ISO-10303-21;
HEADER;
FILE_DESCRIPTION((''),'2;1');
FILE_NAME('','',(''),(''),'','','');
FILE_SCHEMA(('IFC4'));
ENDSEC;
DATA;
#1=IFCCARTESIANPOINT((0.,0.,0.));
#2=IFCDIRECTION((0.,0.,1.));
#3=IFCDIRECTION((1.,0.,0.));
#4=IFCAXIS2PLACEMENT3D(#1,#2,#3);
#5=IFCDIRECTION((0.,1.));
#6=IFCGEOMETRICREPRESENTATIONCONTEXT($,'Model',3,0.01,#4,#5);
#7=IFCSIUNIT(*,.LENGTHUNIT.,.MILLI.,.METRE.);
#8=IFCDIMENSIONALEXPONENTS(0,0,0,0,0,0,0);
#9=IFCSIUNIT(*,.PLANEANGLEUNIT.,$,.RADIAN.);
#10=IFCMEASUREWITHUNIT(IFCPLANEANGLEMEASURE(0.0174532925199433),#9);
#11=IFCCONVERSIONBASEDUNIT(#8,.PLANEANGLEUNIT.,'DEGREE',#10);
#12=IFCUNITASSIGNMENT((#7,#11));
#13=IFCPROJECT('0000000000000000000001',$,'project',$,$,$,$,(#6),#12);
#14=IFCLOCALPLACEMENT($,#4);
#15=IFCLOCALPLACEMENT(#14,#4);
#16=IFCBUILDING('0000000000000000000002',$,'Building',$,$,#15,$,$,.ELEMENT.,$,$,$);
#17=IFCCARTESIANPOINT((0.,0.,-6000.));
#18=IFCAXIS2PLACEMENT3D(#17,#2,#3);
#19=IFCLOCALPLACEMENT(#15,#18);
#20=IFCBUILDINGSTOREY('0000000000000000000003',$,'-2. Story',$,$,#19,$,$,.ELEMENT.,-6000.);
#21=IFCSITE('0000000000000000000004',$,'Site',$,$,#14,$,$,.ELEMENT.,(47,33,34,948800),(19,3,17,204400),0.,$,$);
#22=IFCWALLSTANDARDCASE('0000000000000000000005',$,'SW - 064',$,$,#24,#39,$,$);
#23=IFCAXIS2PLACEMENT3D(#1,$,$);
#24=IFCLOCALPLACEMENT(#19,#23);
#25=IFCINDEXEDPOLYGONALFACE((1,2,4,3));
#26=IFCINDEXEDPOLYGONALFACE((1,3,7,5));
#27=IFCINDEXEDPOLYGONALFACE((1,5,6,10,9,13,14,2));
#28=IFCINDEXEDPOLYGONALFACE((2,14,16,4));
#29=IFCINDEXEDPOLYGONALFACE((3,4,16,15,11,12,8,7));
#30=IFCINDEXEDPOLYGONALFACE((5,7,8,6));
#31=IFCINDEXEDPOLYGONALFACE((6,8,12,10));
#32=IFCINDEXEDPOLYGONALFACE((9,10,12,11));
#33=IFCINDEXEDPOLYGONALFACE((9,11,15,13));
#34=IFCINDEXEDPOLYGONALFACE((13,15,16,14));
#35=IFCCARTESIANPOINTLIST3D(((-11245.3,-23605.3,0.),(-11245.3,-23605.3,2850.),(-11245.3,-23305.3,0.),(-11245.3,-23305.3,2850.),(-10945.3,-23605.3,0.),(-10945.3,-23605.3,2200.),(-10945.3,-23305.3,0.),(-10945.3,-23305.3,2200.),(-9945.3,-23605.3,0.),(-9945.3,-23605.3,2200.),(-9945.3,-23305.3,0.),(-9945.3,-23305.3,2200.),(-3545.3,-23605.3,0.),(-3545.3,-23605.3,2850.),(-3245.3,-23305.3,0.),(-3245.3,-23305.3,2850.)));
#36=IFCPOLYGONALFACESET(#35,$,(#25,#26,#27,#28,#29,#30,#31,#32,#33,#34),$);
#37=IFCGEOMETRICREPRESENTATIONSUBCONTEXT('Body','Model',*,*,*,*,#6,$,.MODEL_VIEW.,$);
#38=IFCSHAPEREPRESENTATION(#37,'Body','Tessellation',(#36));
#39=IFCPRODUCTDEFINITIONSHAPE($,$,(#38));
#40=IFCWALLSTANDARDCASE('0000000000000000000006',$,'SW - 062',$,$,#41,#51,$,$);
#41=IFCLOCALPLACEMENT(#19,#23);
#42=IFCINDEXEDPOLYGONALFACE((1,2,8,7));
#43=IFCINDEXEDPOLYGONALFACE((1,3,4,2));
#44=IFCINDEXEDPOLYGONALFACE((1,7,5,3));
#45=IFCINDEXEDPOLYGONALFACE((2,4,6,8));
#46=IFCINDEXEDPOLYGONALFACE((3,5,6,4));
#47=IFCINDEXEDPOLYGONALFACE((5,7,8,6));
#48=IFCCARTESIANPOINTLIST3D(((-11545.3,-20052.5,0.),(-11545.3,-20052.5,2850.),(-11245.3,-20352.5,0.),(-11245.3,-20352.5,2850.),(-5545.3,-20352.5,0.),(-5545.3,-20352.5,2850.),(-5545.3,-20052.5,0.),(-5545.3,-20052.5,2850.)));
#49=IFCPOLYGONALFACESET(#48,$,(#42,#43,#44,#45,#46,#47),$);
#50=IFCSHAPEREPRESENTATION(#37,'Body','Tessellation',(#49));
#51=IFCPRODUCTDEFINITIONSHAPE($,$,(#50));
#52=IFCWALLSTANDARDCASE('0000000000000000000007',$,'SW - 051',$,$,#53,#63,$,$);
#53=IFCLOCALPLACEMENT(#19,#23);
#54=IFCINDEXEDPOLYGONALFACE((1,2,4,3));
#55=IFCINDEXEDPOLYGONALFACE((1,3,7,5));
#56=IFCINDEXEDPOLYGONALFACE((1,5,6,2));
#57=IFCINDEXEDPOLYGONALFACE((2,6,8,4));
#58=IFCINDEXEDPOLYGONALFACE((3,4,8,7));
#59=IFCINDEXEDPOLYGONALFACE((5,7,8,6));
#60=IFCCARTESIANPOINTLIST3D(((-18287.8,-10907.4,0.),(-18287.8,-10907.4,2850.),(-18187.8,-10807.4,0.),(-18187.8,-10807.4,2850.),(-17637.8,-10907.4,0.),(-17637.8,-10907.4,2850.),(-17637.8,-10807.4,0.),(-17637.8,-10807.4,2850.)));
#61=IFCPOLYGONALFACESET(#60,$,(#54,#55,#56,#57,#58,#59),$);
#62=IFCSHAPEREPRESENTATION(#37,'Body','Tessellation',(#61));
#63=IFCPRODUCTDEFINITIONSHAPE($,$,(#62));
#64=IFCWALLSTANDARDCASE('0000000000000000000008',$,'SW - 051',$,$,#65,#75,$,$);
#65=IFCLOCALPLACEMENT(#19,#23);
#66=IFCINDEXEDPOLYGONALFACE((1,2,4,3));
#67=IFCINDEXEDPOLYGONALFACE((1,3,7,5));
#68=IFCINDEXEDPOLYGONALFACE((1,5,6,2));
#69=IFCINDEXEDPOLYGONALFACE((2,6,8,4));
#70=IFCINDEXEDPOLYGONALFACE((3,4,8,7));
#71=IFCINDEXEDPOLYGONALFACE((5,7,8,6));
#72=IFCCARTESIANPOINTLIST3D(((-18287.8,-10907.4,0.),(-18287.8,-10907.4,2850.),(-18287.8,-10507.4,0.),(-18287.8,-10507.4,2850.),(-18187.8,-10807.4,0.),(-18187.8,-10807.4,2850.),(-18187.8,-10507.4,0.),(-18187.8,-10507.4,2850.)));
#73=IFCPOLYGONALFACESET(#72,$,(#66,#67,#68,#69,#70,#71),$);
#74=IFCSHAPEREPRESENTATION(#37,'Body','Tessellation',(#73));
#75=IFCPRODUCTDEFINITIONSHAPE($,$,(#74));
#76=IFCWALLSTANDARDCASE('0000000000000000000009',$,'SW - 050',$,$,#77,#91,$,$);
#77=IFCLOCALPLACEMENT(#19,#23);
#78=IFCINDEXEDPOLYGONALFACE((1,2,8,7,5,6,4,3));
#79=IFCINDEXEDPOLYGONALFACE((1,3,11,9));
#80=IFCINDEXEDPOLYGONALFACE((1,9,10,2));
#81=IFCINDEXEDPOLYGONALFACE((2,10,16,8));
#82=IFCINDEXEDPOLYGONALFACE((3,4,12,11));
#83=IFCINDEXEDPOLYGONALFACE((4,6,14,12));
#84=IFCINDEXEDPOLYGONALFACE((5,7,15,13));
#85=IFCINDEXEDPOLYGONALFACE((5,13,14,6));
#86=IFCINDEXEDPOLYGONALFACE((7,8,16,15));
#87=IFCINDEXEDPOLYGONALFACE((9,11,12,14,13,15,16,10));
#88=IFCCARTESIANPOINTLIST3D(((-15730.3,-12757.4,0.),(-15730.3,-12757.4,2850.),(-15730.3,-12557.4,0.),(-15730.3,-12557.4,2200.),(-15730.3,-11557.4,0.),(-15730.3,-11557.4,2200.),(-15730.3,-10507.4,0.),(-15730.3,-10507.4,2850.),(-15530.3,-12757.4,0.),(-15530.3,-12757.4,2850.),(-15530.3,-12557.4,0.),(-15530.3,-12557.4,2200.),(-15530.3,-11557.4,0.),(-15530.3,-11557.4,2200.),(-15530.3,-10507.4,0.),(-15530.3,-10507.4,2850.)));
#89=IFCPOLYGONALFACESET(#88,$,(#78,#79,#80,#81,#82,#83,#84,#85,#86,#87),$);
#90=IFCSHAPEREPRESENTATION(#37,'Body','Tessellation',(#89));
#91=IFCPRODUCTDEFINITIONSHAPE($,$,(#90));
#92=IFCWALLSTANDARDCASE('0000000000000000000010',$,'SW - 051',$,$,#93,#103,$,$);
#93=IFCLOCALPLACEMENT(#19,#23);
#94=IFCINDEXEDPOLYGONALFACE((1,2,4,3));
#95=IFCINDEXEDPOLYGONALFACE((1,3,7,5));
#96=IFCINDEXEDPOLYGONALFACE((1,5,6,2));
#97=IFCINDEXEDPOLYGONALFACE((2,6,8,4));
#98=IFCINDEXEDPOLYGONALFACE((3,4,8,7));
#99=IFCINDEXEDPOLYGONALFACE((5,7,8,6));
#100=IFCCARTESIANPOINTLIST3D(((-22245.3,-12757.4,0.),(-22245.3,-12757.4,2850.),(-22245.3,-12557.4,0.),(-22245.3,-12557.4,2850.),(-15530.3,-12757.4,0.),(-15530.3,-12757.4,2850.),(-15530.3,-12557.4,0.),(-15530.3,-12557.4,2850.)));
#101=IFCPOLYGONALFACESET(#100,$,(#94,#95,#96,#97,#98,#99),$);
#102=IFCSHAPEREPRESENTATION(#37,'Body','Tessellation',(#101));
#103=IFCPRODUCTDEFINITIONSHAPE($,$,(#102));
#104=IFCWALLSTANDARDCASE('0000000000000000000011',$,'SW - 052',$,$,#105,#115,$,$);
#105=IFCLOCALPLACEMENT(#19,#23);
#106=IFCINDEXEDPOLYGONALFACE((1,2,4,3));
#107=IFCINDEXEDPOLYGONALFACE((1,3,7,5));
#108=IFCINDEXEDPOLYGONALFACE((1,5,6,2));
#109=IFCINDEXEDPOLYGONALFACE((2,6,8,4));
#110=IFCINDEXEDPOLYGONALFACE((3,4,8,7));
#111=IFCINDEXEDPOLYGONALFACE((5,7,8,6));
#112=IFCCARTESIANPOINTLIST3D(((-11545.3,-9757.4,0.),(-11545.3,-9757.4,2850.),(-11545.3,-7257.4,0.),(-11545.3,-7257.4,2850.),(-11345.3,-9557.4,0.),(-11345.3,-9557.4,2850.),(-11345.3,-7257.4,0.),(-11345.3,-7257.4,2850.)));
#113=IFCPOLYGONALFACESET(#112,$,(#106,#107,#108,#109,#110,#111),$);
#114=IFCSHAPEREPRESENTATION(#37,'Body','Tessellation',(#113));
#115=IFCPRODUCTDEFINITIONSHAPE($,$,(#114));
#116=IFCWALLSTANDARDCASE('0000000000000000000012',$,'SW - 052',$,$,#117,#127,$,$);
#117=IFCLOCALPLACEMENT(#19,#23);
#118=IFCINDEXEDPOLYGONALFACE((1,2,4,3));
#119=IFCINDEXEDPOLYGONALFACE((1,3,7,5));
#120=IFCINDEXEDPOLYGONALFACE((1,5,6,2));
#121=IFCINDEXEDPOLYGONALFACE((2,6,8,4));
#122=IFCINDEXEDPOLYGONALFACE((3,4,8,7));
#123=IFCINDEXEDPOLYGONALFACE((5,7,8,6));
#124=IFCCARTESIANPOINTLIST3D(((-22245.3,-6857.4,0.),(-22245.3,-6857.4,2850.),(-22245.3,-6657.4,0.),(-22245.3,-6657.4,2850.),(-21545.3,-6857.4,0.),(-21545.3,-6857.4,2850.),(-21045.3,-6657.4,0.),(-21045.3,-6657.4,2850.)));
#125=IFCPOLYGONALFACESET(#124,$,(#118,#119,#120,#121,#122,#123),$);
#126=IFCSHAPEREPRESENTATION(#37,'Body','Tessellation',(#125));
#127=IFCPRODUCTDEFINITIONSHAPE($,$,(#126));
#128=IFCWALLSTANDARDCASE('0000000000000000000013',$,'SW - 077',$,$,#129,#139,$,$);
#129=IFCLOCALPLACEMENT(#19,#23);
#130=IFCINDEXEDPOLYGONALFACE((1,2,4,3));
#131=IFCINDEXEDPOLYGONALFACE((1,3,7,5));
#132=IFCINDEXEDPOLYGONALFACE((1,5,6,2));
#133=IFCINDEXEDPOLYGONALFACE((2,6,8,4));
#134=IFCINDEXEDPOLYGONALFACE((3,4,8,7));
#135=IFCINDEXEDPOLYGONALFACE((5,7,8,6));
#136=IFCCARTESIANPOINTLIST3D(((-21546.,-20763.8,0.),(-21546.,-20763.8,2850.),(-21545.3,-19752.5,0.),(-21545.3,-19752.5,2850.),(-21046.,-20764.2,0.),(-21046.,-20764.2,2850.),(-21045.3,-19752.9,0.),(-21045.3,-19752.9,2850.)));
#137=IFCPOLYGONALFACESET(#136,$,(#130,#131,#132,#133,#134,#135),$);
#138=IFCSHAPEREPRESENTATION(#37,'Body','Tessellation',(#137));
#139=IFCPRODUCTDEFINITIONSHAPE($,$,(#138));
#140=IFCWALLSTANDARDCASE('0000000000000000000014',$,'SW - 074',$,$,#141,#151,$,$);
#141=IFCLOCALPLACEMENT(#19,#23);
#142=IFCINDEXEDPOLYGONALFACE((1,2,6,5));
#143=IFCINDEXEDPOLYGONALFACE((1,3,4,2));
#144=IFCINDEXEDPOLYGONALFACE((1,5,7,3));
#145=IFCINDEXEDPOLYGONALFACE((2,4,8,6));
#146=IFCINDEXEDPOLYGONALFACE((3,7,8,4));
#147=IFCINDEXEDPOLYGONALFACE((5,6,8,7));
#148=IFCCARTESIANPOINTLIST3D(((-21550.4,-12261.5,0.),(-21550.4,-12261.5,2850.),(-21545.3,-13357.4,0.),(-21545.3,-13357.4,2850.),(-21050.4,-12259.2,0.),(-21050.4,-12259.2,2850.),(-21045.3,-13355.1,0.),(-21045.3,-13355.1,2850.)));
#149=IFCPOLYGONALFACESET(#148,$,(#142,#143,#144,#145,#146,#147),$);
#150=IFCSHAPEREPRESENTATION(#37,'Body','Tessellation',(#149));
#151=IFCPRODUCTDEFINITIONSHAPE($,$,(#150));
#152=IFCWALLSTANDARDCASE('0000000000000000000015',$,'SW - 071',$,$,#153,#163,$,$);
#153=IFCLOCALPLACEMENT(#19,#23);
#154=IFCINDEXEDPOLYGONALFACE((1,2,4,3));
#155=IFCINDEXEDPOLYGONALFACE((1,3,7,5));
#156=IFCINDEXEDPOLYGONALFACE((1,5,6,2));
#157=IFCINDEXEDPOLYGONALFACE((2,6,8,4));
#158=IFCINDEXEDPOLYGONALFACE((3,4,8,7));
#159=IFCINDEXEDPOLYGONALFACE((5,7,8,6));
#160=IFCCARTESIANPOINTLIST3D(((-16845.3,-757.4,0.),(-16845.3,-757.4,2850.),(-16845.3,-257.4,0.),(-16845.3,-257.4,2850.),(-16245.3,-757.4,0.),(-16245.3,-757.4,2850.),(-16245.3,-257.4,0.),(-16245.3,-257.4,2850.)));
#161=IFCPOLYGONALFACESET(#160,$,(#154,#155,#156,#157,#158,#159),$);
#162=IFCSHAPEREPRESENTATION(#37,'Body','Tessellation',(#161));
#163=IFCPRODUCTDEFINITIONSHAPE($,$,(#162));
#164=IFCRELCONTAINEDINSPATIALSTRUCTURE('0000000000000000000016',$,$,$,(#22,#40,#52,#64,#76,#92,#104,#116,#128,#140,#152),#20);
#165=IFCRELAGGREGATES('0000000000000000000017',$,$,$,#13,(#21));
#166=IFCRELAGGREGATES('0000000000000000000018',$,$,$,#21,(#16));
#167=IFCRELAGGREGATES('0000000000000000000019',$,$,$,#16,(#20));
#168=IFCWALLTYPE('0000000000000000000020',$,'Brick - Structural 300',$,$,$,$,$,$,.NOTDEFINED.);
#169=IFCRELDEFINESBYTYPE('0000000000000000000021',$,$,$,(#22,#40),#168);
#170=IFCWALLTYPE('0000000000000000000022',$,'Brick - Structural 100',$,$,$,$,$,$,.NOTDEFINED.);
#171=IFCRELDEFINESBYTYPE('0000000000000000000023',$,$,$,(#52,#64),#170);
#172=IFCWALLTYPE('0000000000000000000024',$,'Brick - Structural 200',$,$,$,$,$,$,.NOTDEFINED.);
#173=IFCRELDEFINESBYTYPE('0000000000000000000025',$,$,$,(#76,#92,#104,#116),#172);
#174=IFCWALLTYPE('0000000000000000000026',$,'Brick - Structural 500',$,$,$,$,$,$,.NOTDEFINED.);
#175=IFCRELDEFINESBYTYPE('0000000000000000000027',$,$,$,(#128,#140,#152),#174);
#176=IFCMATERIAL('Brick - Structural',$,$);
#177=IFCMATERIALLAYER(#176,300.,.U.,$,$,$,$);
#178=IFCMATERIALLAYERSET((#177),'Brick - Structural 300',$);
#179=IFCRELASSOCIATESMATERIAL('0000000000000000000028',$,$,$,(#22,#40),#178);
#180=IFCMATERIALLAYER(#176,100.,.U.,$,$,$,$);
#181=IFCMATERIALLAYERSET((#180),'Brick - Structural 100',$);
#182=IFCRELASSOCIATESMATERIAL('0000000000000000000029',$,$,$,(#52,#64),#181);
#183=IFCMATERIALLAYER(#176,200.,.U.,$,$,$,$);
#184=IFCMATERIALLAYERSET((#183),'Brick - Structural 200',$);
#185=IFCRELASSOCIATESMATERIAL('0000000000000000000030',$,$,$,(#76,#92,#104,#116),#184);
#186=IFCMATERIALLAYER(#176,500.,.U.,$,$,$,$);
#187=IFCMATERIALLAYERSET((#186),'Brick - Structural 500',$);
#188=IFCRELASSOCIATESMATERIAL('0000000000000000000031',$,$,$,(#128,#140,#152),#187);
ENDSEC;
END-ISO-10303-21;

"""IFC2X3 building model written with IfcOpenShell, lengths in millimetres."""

from ifc_helpers import new_model, entity, si_unit, converted_unit, direction, frame, origin_with_axes, origin_2d_with_axis, place, context, subcontext, project, spatial, polyline, rectangle, outline, extrude, material, layer, layer_set, layer_usage, type_object, element, save


model = new_model("IFC2X3")

# Units and contexts
model_context = context("Model", 3, precision=0.01, world=origin_with_axes(), true_north=direction((0.0, 1.0)))
body_context = subcontext(model_context, "Body", "Model", "MODEL_VIEW")
ifc_project = project(units=[si_unit("LENGTHUNIT", "METRE", prefix="MILLI"), converted_unit("PLANEANGLEUNIT", "DEGREE", entity("IfcPlaneAngleMeasure", 0.0174532925199433), si_unit("PLANEANGLEUNIT", "RADIAN"), dimensions=[0, 0, 0, 0, 0, 0, 0])], contexts=[model_context])

# Site, building, storey
site_placement = place(None, origin_with_axes())
site = spatial("IfcSite", under=ifc_project, at=site_placement, Name="Site", CompositionType="ELEMENT", RefLatitude=(47, 33, 34, 948800), RefLongitude=(19, 3, 17, 204400), RefElevation=0.0)
building_placement = place(site_placement, origin_with_axes())
building = spatial("IfcBuilding", under=site, at=building_placement, Name="Building", CompositionType="ELEMENT")
storey_placement = place(building_placement, frame((0.0, 0.0, -6000.0), z_axis=(0.0, 0.0, 1.0), x_axis=(1.0, 0.0, 0.0)))
storey = spatial("IfcBuildingStorey", under=building, at=storey_placement, Name="-2. Story", CompositionType="ELEMENT", Elevation=-6000.0)

# Shared definitions
ifc_material_1 = material(Name="Brick - Structural")
ifc_layer_1 = layer(ifc_material_1, 300.0, ventilated="UNKNOWN")
ifc_layer_set_1 = layer_set([ifc_layer_1], Name="Brick - Structural 300")
wall_type_1 = type_object("IfcWallType", Name="Brick - Structural 300", PredefinedType="NOTDEFINED")

# Wall, opening
ifc_layer_usage_1 = layer_usage(ifc_layer_set_1, "AXIS2", "NEGATIVE", 0.0)
wall_1_placement = place(storey_placement, frame((-11545.3, -23305.3, 0.0), z_axis=(0.0, 0.0, 1.0), x_axis=(1.0, 0.0, 0.0)))
wall_1 = element("IfcWallStandardCase", 1, at=wall_1_placement, inside=storey, type_object=wall_type_1, material=ifc_layer_usage_1, Name="SW - 064", context=body_context, shape_type="SweptSolid", body=[
    extrude(outline(polyline([(300.0, -300.0), (8000.0, -300.0), (8300.0, 0.0), (300.0, 0.0), (300.0, -300.0)])), origin_with_axes(), (0.0, 0.0, 1.0), 2850.0),
])
opening_1_placement = place(wall_1_placement, frame((1100.0, 0.0, 0.0), z_axis=(0.0, 0.0, 1.0), x_axis=(1.0, 0.0, 0.0)))
element("IfcOpeningElement", 2, at=opening_1_placement, cuts=wall_1, context=body_context, shape_type="SweptSolid", body=[
    extrude(rectangle(XDim=1000.0, YDim=2200.0, at=origin_2d_with_axis()), frame((0.0, 0.0, 1100.0), z_axis=(0.0, -1.0, 0.0), x_axis=(1.0, 0.0, 0.0)), (0.0, 0.0, -1.0), 300.0),
    extrude(rectangle(XDim=1000.0, YDim=2200.0, at=origin_2d_with_axis()), frame((0.0, 0.0, 1100.0), z_axis=(0.0, 1.0, 0.0), x_axis=(1.0, 0.0, 0.0)), (0.0, 0.0, -1.0), 300.0),
])

# Walls
ifc_layer_usage_2 = layer_usage(ifc_layer_set_1, "AXIS2", "NEGATIVE", 0.0)
wall_2_placement = place(storey_placement, frame((-11545.3, -20052.5, 0.0), z_axis=(0.0, 0.0, 1.0), x_axis=(1.0, 0.0, 0.0)))
element("IfcWallStandardCase", 3, at=wall_2_placement, inside=storey, type_object=wall_type_1, material=ifc_layer_usage_2, Name="SW - 062", context=body_context, shape_type="SweptSolid", body=[
    extrude(outline(polyline([(300.0, -300.0), (6000.0, -300.0), (6000.0, 0.0), (0.0, 0.0), (300.0, -300.0)])), origin_with_axes(), (0.0, 0.0, 1.0), 2850.0),
])
ifc_layer_2 = layer(ifc_material_1, 100.0, ventilated="UNKNOWN")
ifc_layer_set_2 = layer_set([ifc_layer_2], Name="Brick - Structural 100")
ifc_layer_usage_3 = layer_usage(ifc_layer_set_2, "AXIS2", "NEGATIVE", 0.0)
wall_type_2 = type_object("IfcWallType", Name="Brick - Structural 100", PredefinedType="NOTDEFINED")
wall_3_placement = place(storey_placement, frame((-17637.8, -10907.4, 0.0), z_axis=(0.0, 0.0, 1.0), x_axis=(-1.0, 0.0, 0.0)))
element("IfcWallStandardCase", 4, at=wall_3_placement, inside=storey, type_object=wall_type_2, material=ifc_layer_usage_3, Name="SW - 051", context=body_context, shape_type="SweptSolid", body=[
    extrude(outline(polyline([(0.0, -100.0), (550.0, -100.0), (650.0, 0.0), (0.0, 0.0), (0.0, -100.0)])), origin_with_axes(), (0.0, 0.0, 1.0), 2850.0),
])
ifc_layer_usage_4 = layer_usage(ifc_layer_set_2, "AXIS2", "NEGATIVE", 0.0)
wall_4_placement = place(storey_placement, frame((-18287.8, -10907.4, 0.0), z_axis=(0.0, 0.0, 1.0), x_axis=(0.0, 1.0, 0.0)))
element("IfcWallStandardCase", 5, at=wall_4_placement, inside=storey, type_object=wall_type_2, material=ifc_layer_usage_4, Name="SW - 051", context=body_context, shape_type="SweptSolid", body=[
    extrude(outline(polyline([(100.0, -100.0), (400.0, -100.0), (400.0, 0.0), (0.0, 0.0), (100.0, -100.0)])), origin_with_axes(), (0.0, 0.0, 1.0), 2850.0),
])

# Wall, opening
ifc_layer_3 = layer(ifc_material_1, 200.0, ventilated="UNKNOWN")
ifc_layer_set_3 = layer_set([ifc_layer_3], Name="Brick - Structural 200")
ifc_layer_usage_5 = layer_usage(ifc_layer_set_3, "AXIS2", "NEGATIVE", 0.0)
wall_type_3 = type_object("IfcWallType", Name="Brick - Structural 200", PredefinedType="NOTDEFINED")
wall_5_placement = place(storey_placement, frame((-15530.3, -10507.4, 0.0), z_axis=(0.0, 0.0, 1.0), x_axis=(0.0, -1.0, 0.0)))
wall_5 = element("IfcWallStandardCase", 6, at=wall_5_placement, inside=storey, type_object=wall_type_3, material=ifc_layer_usage_5, Name="SW - 050", context=body_context, shape_type="SweptSolid", body=[
    extrude(outline(polyline([(0.0, -200.0), (2250.0, -200.0), (2250.0, 0.0), (0.0, 0.0), (0.0, -200.0)])), origin_with_axes(), (0.0, 0.0, 1.0), 2850.0),
])
opening_2_placement = place(wall_5_placement, frame((1550.0, 0.0, 0.0), z_axis=(0.0, 0.0, 1.0), x_axis=(1.0, 0.0, 0.0)))
element("IfcOpeningElement", 7, at=opening_2_placement, cuts=wall_5, context=body_context, shape_type="SweptSolid", body=[
    extrude(rectangle(XDim=1000.0, YDim=2200.0, at=origin_2d_with_axis()), frame((0.0, -200.0, 1100.0), z_axis=(0.0, 1.0, 0.0), x_axis=(1.0, 0.0, 0.0)), (0.0, 0.0, -1.0), 200.0),
    extrude(rectangle(XDim=1000.0, YDim=2200.0, at=origin_2d_with_axis()), frame((0.0, -200.0, 1100.0), z_axis=(0.0, -1.0, 0.0), x_axis=(1.0, 0.0, 0.0)), (0.0, 0.0, -1.0), 200.0),
])

# Walls
ifc_layer_usage_6 = layer_usage(ifc_layer_set_3, "AXIS2", "NEGATIVE", 0.0)
wall_6_placement = place(storey_placement, frame((-15530.3, -12757.4, 0.0), z_axis=(0.0, 0.0, 1.0), x_axis=(-1.0, 0.0, 0.0)))
element("IfcWallStandardCase", 8, at=wall_6_placement, inside=storey, type_object=wall_type_3, material=ifc_layer_usage_6, Name="SW - 051", context=body_context, shape_type="SweptSolid", body=[
    extrude(outline(polyline([(0.0, -200.0), (6715.0, -200.0), (6715.0, 0.0), (0.0, 0.0), (0.0, -200.0)])), origin_with_axes(), (0.0, 0.0, 1.0), 2850.0),
])
ifc_layer_usage_7 = layer_usage(ifc_layer_set_3, "AXIS2", "NEGATIVE", 0.0)
wall_7_placement = place(storey_placement, frame((-11545.3, -9757.4, 0.0), z_axis=(0.0, 0.0, 1.0), x_axis=(0.0, 1.0, 0.0)))
element("IfcWallStandardCase", 9, at=wall_7_placement, inside=storey, type_object=wall_type_3, material=ifc_layer_usage_7, Name="SW - 052", context=body_context, shape_type="SweptSolid", body=[
    extrude(outline(polyline([(200.0, -200.0), (2500.0, -200.0), (2500.0, 0.0), (0.0, 0.0), (200.0, -200.0)])), origin_with_axes(), (0.0, 0.0, 1.0), 2850.0),
])
ifc_layer_usage_8 = layer_usage(ifc_layer_set_3, "AXIS2", "POSITIVE", 0.0)
wall_8_placement = place(storey_placement, frame((-21545.3, -6657.4, 0.0), z_axis=(0.0, 0.0, 1.0), x_axis=(-1.0, 0.0, 0.0)))
element("IfcWallStandardCase", 10, at=wall_8_placement, inside=storey, type_object=wall_type_3, material=ifc_layer_usage_8, Name="SW - 052", context=body_context, shape_type="SweptSolid", body=[
    extrude(outline(polyline([(-500.0, 0.0), (700.0, 0.0), (700.0, 200.0), (0.0, 200.0), (-500.0, 0.0)])), origin_with_axes(), (0.0, 0.0, 1.0), 2850.0),
])
ifc_layer_4 = layer(ifc_material_1, 500.0, ventilated="UNKNOWN")
ifc_layer_set_4 = layer_set([ifc_layer_4], Name="Brick - Structural 500")
ifc_layer_usage_9 = layer_usage(ifc_layer_set_4, "AXIS2", "NEGATIVE", 0.0)
wall_type_4 = type_object("IfcWallType", Name="Brick - Structural 500", PredefinedType="NOTDEFINED")
wall_9_placement = place(storey_placement, frame((-21546.0, -20763.8, 0.0), z_axis=(0.0, 0.0, 1.0), x_axis=(0.000713, 1.0, 0.0)))
element("IfcWallStandardCase", 11, at=wall_9_placement, inside=storey, type_object=wall_type_4, material=ifc_layer_usage_9, Name="SW - 077", context=body_context, shape_type="SweptSolid", body=[
    extrude(outline(polyline([(0.0, -500.0), (1011.3, -500.0), (1011.3, 0.0), (0.0, 0.0), (0.0, -500.0)])), origin_with_axes(), (0.0, 0.0, 1.0), 2850.0),
])
ifc_layer_usage_10 = layer_usage(ifc_layer_set_4, "AXIS2", "POSITIVE", 0.0)
wall_10_placement = place(storey_placement, frame((-21550.4, -12261.5, 0.0), z_axis=(0.0, 0.0, 1.0), x_axis=(0.004603, -0.999989, 0.0)))
element("IfcWallStandardCase", 12, at=wall_10_placement, inside=storey, type_object=wall_type_4, material=ifc_layer_usage_10, Name="SW - 074", context=body_context, shape_type="SweptSolid", body=[
    extrude(outline(polyline([(0.0, 0.0), (1096.0, 0.0), (1096.0, 500.0), (0.0, 500.0), (0.0, 0.0)])), origin_with_axes(), (0.0, 0.0, 1.0), 2850.0),
])
ifc_layer_usage_11 = layer_usage(ifc_layer_set_4, "AXIS2", "POSITIVE", 0.0)
wall_11_placement = place(storey_placement, frame((-16245.3, -257.4, 0.0), z_axis=(0.0, 0.0, 1.0), x_axis=(-1.0, 0.0, 0.0)))
element("IfcWallStandardCase", 13, at=wall_11_placement, inside=storey, type_object=wall_type_4, material=ifc_layer_usage_11, Name="SW - 071", context=body_context, shape_type="SweptSolid", body=[
    extrude(outline(polyline([(0.0, 0.0), (600.0, 0.0), (600.0, 500.0), (0.0, 500.0), (0.0, 0.0)])), origin_with_axes(), (0.0, 0.0, 1.0), 2850.0),
])

save(model, "model.ifc")
